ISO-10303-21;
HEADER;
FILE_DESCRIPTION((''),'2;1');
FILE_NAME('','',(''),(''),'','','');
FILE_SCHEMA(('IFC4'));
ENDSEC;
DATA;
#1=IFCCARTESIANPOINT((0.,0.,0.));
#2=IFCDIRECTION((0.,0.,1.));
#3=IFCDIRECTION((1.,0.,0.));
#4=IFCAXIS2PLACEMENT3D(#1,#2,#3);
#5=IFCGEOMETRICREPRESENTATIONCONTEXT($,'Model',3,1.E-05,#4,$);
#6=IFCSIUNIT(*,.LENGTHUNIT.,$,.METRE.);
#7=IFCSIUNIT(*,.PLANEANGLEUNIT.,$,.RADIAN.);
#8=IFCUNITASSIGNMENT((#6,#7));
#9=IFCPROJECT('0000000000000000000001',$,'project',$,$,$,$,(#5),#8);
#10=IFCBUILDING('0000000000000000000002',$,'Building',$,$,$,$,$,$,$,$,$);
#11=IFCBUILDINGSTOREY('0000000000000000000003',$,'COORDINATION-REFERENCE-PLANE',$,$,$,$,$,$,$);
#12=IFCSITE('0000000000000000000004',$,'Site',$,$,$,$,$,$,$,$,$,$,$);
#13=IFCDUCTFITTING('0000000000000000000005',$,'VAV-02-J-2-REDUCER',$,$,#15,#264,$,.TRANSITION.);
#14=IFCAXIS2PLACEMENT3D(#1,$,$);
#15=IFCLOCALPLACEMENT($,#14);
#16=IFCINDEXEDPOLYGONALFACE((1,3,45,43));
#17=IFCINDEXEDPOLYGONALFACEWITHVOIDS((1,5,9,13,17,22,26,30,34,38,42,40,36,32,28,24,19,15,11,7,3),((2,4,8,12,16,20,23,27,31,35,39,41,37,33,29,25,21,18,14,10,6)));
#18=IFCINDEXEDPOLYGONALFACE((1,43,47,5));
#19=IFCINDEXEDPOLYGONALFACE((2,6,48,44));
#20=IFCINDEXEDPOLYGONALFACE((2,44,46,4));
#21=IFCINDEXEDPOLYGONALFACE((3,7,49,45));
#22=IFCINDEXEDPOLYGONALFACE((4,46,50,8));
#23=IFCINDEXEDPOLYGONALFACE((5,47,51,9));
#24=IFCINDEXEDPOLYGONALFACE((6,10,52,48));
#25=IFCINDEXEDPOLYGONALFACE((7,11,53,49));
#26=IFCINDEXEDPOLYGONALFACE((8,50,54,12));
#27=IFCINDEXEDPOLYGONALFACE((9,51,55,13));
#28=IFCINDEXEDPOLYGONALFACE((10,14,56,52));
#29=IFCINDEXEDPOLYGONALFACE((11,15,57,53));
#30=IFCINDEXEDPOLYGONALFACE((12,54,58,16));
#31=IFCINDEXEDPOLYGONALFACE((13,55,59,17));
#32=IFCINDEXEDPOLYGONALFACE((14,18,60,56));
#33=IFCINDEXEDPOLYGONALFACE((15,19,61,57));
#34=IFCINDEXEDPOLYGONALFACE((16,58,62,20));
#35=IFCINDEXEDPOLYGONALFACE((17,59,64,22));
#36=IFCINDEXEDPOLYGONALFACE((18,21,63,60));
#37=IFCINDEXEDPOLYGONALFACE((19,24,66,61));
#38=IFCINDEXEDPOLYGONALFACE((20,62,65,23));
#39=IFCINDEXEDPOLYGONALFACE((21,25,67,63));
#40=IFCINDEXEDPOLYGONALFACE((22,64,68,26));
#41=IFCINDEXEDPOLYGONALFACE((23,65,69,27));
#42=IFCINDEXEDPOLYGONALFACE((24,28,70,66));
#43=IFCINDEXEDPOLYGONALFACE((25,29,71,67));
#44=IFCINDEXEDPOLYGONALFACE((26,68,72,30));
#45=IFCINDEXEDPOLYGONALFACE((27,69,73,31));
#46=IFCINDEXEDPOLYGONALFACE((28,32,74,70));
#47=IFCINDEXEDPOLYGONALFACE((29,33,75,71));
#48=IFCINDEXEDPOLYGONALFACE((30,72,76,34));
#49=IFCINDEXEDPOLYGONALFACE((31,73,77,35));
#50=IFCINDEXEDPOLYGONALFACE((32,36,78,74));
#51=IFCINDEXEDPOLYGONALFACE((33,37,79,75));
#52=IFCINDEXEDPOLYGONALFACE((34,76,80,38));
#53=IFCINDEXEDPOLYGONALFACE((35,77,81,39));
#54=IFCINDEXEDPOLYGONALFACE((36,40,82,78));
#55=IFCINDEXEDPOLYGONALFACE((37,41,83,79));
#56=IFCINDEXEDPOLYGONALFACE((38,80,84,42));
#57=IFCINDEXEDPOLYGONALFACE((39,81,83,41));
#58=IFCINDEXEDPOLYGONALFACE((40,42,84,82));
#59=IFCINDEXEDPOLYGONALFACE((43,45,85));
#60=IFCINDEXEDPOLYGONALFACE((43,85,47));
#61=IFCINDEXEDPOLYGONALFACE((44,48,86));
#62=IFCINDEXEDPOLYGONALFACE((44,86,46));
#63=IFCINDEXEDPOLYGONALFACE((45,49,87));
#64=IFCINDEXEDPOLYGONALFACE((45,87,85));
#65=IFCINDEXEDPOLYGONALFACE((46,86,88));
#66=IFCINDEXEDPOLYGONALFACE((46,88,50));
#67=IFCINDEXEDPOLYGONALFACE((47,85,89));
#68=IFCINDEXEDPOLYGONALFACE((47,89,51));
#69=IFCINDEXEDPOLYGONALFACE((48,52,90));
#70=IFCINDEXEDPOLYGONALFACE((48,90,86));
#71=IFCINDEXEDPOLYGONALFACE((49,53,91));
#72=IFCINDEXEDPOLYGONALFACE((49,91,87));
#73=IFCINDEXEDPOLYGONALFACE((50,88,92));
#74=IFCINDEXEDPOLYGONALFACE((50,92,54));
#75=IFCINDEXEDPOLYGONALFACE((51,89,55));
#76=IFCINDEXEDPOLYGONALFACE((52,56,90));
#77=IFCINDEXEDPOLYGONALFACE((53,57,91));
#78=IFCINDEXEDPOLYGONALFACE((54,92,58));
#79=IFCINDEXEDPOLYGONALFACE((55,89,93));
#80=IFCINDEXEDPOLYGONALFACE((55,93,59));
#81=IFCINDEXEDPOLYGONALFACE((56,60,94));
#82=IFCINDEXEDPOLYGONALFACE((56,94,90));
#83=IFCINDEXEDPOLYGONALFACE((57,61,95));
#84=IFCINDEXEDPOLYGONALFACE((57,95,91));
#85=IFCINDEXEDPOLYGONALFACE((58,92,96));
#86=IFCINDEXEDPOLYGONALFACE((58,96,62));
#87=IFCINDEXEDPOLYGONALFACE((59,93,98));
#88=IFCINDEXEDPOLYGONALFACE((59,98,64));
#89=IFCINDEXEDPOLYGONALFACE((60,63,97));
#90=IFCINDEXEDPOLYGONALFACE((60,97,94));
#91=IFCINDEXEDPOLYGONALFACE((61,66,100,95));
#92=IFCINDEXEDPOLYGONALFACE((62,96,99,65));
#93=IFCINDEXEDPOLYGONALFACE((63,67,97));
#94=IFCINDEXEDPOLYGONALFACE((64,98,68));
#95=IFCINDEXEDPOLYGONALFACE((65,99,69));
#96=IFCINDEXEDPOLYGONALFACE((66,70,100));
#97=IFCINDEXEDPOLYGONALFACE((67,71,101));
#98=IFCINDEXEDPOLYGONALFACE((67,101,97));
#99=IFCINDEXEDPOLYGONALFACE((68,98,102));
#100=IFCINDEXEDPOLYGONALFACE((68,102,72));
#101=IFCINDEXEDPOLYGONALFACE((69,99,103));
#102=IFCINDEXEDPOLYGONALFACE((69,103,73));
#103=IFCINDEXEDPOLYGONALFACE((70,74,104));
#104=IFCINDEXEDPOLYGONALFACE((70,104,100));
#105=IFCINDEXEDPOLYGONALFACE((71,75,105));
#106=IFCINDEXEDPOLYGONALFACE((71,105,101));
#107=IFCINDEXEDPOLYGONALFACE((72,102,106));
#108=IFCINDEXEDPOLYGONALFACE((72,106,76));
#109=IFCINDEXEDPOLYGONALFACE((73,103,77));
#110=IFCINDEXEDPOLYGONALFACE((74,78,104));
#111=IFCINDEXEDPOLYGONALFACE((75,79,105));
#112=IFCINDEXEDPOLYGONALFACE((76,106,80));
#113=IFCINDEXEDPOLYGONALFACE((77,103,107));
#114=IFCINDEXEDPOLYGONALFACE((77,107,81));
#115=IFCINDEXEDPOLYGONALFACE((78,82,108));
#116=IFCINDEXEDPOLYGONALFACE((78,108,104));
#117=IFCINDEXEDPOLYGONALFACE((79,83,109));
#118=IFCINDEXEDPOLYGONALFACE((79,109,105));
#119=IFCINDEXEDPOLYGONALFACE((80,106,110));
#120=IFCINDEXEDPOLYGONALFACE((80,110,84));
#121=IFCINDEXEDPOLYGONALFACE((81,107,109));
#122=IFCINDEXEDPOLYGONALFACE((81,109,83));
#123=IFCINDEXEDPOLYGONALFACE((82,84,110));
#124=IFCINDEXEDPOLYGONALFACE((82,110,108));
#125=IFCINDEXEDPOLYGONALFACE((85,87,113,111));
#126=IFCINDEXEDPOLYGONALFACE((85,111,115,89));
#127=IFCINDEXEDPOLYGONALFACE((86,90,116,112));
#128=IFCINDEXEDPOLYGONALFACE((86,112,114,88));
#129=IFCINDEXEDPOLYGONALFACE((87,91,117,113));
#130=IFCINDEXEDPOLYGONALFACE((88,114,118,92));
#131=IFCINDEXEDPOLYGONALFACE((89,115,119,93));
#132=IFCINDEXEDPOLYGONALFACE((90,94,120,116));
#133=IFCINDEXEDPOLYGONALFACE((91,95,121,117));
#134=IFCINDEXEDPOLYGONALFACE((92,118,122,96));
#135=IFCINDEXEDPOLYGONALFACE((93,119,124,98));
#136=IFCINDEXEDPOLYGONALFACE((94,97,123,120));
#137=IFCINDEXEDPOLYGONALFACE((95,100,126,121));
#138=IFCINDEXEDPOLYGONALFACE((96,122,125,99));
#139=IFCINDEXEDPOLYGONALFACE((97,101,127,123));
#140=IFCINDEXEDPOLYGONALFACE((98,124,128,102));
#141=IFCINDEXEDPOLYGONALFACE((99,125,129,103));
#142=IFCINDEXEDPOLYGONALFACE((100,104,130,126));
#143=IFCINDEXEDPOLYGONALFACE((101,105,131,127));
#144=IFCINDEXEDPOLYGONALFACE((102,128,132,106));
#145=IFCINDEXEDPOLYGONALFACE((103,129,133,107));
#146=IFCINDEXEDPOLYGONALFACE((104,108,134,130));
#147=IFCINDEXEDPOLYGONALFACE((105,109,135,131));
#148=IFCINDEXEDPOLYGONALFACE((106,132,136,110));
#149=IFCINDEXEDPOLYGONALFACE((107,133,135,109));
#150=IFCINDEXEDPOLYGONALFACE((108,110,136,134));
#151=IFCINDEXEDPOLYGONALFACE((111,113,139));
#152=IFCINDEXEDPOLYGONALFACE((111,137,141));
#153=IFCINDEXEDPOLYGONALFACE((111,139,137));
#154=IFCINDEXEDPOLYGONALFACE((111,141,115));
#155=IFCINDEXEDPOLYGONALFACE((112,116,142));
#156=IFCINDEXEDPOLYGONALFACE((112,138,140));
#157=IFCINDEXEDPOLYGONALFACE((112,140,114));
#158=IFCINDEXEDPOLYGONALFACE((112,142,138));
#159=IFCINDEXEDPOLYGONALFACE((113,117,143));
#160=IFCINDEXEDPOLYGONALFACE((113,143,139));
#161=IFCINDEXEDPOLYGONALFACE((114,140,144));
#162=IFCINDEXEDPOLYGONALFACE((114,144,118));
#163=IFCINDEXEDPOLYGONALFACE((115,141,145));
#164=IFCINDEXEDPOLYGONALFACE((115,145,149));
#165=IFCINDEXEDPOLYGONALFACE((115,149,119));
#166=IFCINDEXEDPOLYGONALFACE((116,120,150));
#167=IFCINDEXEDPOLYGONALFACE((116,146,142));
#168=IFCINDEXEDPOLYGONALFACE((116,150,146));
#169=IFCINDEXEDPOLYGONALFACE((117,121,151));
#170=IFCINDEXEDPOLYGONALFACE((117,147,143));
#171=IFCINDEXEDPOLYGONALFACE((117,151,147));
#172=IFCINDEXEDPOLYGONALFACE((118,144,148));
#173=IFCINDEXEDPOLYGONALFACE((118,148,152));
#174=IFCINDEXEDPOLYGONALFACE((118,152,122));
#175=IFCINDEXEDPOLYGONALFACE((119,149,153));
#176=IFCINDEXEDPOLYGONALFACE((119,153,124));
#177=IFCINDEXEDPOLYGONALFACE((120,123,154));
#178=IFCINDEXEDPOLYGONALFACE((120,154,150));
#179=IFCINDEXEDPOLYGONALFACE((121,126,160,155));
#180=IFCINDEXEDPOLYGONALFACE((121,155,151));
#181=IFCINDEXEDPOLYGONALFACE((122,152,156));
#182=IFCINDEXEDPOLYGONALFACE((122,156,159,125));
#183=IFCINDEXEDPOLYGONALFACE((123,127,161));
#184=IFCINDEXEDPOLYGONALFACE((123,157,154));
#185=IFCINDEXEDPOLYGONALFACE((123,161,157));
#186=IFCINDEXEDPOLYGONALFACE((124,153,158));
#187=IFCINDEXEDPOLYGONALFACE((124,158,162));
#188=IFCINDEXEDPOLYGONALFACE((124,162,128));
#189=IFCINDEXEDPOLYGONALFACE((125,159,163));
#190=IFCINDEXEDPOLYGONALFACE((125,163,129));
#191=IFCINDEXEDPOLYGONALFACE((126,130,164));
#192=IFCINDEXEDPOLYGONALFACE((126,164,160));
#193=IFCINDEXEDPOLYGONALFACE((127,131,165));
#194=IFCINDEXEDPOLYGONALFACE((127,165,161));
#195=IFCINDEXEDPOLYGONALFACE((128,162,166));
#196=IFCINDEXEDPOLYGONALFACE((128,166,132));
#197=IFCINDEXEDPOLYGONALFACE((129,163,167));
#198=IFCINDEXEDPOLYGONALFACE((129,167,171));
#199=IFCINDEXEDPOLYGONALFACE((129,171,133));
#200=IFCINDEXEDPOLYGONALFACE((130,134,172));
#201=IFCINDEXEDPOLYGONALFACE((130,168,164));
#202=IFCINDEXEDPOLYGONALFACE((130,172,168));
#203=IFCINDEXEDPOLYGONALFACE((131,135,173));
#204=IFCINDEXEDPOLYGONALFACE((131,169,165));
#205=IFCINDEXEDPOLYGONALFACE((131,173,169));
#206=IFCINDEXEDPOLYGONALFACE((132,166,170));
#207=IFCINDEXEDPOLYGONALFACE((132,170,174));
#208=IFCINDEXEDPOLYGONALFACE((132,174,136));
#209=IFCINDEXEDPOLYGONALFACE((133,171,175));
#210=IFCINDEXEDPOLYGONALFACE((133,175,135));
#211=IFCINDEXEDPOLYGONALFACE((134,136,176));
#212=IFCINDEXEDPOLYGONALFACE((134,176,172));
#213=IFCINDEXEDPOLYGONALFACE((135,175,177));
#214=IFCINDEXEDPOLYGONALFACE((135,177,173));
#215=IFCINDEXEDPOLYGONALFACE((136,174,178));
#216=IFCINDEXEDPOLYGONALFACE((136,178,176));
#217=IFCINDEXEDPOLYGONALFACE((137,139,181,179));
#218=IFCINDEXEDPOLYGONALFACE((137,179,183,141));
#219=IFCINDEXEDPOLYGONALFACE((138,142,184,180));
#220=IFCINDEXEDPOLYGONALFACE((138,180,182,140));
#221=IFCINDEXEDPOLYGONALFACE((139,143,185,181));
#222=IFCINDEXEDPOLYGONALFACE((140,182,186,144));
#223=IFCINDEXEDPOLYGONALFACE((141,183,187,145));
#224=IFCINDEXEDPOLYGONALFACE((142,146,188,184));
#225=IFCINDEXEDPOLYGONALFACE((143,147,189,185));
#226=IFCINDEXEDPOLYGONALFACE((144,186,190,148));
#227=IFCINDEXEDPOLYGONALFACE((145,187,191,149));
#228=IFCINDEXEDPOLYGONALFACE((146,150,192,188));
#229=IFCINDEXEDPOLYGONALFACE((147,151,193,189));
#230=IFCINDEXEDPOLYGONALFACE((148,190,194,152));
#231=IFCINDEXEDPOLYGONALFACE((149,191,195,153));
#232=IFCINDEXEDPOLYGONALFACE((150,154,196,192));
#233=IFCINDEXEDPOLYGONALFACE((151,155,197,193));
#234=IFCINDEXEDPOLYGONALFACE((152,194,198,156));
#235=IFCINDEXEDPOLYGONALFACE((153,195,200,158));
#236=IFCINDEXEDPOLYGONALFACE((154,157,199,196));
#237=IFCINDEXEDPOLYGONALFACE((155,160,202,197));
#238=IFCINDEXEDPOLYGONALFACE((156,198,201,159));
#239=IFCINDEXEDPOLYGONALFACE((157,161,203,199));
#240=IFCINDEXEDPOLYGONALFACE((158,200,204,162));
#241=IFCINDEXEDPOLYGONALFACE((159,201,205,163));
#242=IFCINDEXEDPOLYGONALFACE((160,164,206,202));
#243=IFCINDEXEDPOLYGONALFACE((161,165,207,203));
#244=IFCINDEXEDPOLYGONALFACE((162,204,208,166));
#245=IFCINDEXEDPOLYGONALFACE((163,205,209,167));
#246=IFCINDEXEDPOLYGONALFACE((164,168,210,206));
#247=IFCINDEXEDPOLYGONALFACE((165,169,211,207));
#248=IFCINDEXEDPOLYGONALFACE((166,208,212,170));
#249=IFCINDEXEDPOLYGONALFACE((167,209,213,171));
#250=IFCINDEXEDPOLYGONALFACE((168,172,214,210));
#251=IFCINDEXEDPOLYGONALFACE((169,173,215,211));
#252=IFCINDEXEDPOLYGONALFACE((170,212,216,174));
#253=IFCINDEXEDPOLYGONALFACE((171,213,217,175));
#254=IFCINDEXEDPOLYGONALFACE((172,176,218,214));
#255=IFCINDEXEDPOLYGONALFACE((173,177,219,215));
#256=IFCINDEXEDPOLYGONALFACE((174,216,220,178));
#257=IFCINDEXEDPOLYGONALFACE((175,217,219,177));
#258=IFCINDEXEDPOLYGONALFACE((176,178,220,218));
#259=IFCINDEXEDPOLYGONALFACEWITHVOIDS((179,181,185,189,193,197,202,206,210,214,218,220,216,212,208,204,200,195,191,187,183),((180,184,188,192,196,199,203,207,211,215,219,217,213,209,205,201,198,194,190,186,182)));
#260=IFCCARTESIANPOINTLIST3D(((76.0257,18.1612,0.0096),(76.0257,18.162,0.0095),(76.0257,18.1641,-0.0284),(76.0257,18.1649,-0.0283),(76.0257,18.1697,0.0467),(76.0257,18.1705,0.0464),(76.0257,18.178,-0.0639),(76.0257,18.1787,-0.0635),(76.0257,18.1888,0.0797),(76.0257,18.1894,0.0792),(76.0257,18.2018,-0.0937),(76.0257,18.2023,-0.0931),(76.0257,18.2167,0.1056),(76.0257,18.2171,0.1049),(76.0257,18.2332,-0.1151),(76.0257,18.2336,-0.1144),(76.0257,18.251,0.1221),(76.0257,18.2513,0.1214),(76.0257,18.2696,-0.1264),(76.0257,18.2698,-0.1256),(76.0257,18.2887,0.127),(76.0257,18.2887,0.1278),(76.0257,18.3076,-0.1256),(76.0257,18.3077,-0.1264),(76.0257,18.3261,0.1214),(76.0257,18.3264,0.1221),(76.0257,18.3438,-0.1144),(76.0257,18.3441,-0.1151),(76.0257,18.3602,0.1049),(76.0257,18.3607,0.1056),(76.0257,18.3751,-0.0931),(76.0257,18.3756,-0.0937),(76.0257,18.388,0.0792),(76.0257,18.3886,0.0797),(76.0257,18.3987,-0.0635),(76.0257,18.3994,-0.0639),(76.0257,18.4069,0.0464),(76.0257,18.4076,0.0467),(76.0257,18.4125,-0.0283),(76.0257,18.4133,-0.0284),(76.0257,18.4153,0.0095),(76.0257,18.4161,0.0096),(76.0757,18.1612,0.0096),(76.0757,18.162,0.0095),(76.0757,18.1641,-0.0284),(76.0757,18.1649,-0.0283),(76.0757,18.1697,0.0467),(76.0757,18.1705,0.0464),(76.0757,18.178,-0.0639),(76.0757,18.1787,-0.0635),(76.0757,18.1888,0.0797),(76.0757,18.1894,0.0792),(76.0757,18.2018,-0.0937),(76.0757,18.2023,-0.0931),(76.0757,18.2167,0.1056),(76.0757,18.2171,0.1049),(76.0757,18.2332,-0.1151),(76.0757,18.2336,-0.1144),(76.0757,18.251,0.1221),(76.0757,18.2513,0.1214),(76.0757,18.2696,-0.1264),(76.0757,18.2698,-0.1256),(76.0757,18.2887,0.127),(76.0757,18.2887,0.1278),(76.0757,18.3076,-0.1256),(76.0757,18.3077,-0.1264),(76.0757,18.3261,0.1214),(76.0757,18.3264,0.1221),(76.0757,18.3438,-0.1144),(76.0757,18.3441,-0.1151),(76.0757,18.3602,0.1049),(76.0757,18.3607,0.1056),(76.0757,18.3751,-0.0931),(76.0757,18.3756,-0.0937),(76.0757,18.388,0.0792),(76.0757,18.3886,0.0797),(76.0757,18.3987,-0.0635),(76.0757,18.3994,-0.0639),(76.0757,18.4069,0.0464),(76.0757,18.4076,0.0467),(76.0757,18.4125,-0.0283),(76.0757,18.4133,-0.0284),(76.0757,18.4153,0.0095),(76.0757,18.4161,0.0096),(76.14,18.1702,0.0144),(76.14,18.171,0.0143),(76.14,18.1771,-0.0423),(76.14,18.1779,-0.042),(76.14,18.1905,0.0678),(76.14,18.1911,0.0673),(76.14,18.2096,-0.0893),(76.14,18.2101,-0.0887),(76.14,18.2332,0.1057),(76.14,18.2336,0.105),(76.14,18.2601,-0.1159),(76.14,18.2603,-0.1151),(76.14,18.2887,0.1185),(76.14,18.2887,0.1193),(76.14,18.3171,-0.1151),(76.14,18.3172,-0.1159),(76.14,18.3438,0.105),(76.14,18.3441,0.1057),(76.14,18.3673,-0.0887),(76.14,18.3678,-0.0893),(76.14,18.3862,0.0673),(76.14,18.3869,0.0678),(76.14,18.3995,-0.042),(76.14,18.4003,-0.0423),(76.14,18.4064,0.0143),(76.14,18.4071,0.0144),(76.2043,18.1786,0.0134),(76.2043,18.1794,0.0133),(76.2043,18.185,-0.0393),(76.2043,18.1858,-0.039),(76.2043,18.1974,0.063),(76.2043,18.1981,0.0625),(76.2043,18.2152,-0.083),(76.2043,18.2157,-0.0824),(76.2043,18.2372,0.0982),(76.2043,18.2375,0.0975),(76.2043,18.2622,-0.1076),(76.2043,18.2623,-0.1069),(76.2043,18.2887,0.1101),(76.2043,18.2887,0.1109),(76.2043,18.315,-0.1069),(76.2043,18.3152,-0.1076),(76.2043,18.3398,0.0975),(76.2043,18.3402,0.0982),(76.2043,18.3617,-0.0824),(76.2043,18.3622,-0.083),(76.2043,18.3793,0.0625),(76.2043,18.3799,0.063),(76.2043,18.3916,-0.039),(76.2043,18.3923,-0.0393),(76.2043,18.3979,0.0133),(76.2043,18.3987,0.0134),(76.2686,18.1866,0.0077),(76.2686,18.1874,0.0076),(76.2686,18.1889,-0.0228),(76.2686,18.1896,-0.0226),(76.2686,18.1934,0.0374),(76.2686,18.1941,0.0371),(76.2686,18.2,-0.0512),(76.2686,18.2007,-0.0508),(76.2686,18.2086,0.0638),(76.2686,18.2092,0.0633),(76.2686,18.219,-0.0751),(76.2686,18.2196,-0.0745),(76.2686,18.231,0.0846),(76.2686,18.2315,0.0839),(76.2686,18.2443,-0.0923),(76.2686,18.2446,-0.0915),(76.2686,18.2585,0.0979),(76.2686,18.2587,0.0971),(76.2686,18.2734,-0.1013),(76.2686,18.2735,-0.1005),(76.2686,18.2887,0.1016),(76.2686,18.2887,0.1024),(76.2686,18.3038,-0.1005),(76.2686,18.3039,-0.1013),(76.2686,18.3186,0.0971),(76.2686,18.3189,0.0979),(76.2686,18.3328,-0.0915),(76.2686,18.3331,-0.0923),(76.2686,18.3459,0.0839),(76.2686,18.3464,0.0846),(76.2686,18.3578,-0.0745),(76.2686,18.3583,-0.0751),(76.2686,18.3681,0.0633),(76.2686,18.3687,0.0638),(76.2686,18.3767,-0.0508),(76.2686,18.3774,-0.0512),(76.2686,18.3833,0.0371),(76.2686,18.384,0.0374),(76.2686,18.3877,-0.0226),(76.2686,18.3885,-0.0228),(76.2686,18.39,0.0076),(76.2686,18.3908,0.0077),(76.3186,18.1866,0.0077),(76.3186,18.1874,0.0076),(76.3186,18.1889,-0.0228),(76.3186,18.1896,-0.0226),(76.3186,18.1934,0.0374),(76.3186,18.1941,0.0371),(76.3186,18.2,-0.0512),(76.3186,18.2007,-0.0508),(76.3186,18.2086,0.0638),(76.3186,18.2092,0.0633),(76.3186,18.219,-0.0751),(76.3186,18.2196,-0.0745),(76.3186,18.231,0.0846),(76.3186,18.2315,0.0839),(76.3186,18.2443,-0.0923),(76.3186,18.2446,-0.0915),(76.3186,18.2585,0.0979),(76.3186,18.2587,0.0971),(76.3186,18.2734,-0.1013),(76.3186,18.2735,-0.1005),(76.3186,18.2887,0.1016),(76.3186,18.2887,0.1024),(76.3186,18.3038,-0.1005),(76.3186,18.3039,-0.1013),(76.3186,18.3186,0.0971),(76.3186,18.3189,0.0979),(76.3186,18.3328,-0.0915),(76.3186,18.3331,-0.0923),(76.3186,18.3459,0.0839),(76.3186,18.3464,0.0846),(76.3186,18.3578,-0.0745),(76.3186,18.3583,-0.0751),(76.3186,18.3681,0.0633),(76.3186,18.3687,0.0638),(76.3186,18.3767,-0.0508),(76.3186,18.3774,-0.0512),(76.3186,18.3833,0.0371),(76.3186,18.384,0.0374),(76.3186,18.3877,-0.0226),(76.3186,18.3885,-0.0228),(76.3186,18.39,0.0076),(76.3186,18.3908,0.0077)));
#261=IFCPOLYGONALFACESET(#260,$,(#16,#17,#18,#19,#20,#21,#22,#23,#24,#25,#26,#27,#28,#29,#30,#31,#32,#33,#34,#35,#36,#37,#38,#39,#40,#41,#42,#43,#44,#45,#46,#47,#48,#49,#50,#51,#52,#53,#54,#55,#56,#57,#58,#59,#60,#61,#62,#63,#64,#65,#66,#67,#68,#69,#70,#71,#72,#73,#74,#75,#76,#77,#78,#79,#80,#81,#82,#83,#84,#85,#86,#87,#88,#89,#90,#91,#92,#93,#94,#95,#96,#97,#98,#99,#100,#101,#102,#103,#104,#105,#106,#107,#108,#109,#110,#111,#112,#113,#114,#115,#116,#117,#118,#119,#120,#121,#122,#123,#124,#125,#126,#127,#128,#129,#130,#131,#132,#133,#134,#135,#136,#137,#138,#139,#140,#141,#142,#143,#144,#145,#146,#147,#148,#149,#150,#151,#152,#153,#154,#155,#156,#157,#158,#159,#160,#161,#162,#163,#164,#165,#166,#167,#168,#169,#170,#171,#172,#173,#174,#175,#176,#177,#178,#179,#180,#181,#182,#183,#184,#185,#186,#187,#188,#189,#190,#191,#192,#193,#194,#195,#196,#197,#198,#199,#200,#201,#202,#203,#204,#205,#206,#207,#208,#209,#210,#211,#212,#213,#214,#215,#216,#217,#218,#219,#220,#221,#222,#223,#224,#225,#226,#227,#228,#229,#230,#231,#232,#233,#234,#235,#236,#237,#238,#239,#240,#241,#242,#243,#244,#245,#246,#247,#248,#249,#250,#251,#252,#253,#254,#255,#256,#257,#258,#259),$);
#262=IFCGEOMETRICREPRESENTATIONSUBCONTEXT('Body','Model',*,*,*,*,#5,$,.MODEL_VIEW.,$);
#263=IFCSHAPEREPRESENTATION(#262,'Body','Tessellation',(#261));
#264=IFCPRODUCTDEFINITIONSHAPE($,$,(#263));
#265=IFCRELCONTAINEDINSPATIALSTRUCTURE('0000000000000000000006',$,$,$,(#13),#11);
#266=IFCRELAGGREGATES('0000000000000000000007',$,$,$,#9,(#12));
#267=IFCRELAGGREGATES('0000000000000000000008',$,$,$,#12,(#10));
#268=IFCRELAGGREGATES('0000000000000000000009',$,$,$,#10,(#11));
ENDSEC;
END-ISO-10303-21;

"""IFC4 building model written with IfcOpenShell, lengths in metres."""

from ifc_helpers import new_model, entity, si_unit, frame, origin_with_axes, place, context, subcontext, project, spatial, element, save


model = new_model("IFC4")

# Units and contexts
model_context = context("Model", 3, precision=1e-05, world=origin_with_axes())
body_context_1 = subcontext(model_context, "Body", "Model", "MODEL_VIEW")
ifc_project = project(units=[si_unit("LENGTHUNIT", "METRE"), si_unit("PLANEANGLEUNIT", "RADIAN")], contexts=[model_context])

# Site, building, storey
site = spatial("IfcSite", under=ifc_project, Name="Site")
building = spatial("IfcBuilding", under=site, Name="Building")
storey = spatial("IfcBuildingStorey", under=building, Name="COORDINATION-REFERENCE-PLANE")

# Duct fitting
for number, where, z_axis, x_axis, name in (
    (1, (76.0257, 18.2887, 0.0), (0.0, 1.0, 0.0), (0.0, 0.0, 1.0), "VAV-02-J-2-REDUCER"),
):
    element("IfcDuctFitting", number, at=place(None, frame(where, z_axis=z_axis, x_axis=x_axis)), inside=storey, Name=name, PredefinedType="TRANSITION", context=body_context_1, shape_type="SweptSolid", body=[
        entity("IfcRevolvedAreaSolid", entity("IfcArbitraryClosedProfileDef", "AREA", None, entity("IfcPolyline", [entity("IfcCartesianPoint", [0.1278, 0.0]), entity("IfcCartesianPoint", [0.1278, 0.05]), entity("IfcCartesianPoint", [0.1024, 0.2429]), entity("IfcCartesianPoint", [0.1024, 0.2929]), entity("IfcCartesianPoint", [0.1016, 0.2929]), entity("IfcCartesianPoint", [0.1016, 0.2429]), entity("IfcCartesianPoint", [0.127, 0.05]), entity("IfcCartesianPoint", [0.127, 0.0]), entity("IfcCartesianPoint", [0.1278, 0.0])])), entity("IfcAxis2Placement3D", entity("IfcCartesianPoint", [0.0, 0.0, 0.0])), entity("IfcAxis1Placement", entity("IfcCartesianPoint", [0.0, 0.0, 0.0]), entity("IfcDirection", [0.0, 1.0, 0.0])), 6.283185),
    ])

save(model, "model.ifc")
